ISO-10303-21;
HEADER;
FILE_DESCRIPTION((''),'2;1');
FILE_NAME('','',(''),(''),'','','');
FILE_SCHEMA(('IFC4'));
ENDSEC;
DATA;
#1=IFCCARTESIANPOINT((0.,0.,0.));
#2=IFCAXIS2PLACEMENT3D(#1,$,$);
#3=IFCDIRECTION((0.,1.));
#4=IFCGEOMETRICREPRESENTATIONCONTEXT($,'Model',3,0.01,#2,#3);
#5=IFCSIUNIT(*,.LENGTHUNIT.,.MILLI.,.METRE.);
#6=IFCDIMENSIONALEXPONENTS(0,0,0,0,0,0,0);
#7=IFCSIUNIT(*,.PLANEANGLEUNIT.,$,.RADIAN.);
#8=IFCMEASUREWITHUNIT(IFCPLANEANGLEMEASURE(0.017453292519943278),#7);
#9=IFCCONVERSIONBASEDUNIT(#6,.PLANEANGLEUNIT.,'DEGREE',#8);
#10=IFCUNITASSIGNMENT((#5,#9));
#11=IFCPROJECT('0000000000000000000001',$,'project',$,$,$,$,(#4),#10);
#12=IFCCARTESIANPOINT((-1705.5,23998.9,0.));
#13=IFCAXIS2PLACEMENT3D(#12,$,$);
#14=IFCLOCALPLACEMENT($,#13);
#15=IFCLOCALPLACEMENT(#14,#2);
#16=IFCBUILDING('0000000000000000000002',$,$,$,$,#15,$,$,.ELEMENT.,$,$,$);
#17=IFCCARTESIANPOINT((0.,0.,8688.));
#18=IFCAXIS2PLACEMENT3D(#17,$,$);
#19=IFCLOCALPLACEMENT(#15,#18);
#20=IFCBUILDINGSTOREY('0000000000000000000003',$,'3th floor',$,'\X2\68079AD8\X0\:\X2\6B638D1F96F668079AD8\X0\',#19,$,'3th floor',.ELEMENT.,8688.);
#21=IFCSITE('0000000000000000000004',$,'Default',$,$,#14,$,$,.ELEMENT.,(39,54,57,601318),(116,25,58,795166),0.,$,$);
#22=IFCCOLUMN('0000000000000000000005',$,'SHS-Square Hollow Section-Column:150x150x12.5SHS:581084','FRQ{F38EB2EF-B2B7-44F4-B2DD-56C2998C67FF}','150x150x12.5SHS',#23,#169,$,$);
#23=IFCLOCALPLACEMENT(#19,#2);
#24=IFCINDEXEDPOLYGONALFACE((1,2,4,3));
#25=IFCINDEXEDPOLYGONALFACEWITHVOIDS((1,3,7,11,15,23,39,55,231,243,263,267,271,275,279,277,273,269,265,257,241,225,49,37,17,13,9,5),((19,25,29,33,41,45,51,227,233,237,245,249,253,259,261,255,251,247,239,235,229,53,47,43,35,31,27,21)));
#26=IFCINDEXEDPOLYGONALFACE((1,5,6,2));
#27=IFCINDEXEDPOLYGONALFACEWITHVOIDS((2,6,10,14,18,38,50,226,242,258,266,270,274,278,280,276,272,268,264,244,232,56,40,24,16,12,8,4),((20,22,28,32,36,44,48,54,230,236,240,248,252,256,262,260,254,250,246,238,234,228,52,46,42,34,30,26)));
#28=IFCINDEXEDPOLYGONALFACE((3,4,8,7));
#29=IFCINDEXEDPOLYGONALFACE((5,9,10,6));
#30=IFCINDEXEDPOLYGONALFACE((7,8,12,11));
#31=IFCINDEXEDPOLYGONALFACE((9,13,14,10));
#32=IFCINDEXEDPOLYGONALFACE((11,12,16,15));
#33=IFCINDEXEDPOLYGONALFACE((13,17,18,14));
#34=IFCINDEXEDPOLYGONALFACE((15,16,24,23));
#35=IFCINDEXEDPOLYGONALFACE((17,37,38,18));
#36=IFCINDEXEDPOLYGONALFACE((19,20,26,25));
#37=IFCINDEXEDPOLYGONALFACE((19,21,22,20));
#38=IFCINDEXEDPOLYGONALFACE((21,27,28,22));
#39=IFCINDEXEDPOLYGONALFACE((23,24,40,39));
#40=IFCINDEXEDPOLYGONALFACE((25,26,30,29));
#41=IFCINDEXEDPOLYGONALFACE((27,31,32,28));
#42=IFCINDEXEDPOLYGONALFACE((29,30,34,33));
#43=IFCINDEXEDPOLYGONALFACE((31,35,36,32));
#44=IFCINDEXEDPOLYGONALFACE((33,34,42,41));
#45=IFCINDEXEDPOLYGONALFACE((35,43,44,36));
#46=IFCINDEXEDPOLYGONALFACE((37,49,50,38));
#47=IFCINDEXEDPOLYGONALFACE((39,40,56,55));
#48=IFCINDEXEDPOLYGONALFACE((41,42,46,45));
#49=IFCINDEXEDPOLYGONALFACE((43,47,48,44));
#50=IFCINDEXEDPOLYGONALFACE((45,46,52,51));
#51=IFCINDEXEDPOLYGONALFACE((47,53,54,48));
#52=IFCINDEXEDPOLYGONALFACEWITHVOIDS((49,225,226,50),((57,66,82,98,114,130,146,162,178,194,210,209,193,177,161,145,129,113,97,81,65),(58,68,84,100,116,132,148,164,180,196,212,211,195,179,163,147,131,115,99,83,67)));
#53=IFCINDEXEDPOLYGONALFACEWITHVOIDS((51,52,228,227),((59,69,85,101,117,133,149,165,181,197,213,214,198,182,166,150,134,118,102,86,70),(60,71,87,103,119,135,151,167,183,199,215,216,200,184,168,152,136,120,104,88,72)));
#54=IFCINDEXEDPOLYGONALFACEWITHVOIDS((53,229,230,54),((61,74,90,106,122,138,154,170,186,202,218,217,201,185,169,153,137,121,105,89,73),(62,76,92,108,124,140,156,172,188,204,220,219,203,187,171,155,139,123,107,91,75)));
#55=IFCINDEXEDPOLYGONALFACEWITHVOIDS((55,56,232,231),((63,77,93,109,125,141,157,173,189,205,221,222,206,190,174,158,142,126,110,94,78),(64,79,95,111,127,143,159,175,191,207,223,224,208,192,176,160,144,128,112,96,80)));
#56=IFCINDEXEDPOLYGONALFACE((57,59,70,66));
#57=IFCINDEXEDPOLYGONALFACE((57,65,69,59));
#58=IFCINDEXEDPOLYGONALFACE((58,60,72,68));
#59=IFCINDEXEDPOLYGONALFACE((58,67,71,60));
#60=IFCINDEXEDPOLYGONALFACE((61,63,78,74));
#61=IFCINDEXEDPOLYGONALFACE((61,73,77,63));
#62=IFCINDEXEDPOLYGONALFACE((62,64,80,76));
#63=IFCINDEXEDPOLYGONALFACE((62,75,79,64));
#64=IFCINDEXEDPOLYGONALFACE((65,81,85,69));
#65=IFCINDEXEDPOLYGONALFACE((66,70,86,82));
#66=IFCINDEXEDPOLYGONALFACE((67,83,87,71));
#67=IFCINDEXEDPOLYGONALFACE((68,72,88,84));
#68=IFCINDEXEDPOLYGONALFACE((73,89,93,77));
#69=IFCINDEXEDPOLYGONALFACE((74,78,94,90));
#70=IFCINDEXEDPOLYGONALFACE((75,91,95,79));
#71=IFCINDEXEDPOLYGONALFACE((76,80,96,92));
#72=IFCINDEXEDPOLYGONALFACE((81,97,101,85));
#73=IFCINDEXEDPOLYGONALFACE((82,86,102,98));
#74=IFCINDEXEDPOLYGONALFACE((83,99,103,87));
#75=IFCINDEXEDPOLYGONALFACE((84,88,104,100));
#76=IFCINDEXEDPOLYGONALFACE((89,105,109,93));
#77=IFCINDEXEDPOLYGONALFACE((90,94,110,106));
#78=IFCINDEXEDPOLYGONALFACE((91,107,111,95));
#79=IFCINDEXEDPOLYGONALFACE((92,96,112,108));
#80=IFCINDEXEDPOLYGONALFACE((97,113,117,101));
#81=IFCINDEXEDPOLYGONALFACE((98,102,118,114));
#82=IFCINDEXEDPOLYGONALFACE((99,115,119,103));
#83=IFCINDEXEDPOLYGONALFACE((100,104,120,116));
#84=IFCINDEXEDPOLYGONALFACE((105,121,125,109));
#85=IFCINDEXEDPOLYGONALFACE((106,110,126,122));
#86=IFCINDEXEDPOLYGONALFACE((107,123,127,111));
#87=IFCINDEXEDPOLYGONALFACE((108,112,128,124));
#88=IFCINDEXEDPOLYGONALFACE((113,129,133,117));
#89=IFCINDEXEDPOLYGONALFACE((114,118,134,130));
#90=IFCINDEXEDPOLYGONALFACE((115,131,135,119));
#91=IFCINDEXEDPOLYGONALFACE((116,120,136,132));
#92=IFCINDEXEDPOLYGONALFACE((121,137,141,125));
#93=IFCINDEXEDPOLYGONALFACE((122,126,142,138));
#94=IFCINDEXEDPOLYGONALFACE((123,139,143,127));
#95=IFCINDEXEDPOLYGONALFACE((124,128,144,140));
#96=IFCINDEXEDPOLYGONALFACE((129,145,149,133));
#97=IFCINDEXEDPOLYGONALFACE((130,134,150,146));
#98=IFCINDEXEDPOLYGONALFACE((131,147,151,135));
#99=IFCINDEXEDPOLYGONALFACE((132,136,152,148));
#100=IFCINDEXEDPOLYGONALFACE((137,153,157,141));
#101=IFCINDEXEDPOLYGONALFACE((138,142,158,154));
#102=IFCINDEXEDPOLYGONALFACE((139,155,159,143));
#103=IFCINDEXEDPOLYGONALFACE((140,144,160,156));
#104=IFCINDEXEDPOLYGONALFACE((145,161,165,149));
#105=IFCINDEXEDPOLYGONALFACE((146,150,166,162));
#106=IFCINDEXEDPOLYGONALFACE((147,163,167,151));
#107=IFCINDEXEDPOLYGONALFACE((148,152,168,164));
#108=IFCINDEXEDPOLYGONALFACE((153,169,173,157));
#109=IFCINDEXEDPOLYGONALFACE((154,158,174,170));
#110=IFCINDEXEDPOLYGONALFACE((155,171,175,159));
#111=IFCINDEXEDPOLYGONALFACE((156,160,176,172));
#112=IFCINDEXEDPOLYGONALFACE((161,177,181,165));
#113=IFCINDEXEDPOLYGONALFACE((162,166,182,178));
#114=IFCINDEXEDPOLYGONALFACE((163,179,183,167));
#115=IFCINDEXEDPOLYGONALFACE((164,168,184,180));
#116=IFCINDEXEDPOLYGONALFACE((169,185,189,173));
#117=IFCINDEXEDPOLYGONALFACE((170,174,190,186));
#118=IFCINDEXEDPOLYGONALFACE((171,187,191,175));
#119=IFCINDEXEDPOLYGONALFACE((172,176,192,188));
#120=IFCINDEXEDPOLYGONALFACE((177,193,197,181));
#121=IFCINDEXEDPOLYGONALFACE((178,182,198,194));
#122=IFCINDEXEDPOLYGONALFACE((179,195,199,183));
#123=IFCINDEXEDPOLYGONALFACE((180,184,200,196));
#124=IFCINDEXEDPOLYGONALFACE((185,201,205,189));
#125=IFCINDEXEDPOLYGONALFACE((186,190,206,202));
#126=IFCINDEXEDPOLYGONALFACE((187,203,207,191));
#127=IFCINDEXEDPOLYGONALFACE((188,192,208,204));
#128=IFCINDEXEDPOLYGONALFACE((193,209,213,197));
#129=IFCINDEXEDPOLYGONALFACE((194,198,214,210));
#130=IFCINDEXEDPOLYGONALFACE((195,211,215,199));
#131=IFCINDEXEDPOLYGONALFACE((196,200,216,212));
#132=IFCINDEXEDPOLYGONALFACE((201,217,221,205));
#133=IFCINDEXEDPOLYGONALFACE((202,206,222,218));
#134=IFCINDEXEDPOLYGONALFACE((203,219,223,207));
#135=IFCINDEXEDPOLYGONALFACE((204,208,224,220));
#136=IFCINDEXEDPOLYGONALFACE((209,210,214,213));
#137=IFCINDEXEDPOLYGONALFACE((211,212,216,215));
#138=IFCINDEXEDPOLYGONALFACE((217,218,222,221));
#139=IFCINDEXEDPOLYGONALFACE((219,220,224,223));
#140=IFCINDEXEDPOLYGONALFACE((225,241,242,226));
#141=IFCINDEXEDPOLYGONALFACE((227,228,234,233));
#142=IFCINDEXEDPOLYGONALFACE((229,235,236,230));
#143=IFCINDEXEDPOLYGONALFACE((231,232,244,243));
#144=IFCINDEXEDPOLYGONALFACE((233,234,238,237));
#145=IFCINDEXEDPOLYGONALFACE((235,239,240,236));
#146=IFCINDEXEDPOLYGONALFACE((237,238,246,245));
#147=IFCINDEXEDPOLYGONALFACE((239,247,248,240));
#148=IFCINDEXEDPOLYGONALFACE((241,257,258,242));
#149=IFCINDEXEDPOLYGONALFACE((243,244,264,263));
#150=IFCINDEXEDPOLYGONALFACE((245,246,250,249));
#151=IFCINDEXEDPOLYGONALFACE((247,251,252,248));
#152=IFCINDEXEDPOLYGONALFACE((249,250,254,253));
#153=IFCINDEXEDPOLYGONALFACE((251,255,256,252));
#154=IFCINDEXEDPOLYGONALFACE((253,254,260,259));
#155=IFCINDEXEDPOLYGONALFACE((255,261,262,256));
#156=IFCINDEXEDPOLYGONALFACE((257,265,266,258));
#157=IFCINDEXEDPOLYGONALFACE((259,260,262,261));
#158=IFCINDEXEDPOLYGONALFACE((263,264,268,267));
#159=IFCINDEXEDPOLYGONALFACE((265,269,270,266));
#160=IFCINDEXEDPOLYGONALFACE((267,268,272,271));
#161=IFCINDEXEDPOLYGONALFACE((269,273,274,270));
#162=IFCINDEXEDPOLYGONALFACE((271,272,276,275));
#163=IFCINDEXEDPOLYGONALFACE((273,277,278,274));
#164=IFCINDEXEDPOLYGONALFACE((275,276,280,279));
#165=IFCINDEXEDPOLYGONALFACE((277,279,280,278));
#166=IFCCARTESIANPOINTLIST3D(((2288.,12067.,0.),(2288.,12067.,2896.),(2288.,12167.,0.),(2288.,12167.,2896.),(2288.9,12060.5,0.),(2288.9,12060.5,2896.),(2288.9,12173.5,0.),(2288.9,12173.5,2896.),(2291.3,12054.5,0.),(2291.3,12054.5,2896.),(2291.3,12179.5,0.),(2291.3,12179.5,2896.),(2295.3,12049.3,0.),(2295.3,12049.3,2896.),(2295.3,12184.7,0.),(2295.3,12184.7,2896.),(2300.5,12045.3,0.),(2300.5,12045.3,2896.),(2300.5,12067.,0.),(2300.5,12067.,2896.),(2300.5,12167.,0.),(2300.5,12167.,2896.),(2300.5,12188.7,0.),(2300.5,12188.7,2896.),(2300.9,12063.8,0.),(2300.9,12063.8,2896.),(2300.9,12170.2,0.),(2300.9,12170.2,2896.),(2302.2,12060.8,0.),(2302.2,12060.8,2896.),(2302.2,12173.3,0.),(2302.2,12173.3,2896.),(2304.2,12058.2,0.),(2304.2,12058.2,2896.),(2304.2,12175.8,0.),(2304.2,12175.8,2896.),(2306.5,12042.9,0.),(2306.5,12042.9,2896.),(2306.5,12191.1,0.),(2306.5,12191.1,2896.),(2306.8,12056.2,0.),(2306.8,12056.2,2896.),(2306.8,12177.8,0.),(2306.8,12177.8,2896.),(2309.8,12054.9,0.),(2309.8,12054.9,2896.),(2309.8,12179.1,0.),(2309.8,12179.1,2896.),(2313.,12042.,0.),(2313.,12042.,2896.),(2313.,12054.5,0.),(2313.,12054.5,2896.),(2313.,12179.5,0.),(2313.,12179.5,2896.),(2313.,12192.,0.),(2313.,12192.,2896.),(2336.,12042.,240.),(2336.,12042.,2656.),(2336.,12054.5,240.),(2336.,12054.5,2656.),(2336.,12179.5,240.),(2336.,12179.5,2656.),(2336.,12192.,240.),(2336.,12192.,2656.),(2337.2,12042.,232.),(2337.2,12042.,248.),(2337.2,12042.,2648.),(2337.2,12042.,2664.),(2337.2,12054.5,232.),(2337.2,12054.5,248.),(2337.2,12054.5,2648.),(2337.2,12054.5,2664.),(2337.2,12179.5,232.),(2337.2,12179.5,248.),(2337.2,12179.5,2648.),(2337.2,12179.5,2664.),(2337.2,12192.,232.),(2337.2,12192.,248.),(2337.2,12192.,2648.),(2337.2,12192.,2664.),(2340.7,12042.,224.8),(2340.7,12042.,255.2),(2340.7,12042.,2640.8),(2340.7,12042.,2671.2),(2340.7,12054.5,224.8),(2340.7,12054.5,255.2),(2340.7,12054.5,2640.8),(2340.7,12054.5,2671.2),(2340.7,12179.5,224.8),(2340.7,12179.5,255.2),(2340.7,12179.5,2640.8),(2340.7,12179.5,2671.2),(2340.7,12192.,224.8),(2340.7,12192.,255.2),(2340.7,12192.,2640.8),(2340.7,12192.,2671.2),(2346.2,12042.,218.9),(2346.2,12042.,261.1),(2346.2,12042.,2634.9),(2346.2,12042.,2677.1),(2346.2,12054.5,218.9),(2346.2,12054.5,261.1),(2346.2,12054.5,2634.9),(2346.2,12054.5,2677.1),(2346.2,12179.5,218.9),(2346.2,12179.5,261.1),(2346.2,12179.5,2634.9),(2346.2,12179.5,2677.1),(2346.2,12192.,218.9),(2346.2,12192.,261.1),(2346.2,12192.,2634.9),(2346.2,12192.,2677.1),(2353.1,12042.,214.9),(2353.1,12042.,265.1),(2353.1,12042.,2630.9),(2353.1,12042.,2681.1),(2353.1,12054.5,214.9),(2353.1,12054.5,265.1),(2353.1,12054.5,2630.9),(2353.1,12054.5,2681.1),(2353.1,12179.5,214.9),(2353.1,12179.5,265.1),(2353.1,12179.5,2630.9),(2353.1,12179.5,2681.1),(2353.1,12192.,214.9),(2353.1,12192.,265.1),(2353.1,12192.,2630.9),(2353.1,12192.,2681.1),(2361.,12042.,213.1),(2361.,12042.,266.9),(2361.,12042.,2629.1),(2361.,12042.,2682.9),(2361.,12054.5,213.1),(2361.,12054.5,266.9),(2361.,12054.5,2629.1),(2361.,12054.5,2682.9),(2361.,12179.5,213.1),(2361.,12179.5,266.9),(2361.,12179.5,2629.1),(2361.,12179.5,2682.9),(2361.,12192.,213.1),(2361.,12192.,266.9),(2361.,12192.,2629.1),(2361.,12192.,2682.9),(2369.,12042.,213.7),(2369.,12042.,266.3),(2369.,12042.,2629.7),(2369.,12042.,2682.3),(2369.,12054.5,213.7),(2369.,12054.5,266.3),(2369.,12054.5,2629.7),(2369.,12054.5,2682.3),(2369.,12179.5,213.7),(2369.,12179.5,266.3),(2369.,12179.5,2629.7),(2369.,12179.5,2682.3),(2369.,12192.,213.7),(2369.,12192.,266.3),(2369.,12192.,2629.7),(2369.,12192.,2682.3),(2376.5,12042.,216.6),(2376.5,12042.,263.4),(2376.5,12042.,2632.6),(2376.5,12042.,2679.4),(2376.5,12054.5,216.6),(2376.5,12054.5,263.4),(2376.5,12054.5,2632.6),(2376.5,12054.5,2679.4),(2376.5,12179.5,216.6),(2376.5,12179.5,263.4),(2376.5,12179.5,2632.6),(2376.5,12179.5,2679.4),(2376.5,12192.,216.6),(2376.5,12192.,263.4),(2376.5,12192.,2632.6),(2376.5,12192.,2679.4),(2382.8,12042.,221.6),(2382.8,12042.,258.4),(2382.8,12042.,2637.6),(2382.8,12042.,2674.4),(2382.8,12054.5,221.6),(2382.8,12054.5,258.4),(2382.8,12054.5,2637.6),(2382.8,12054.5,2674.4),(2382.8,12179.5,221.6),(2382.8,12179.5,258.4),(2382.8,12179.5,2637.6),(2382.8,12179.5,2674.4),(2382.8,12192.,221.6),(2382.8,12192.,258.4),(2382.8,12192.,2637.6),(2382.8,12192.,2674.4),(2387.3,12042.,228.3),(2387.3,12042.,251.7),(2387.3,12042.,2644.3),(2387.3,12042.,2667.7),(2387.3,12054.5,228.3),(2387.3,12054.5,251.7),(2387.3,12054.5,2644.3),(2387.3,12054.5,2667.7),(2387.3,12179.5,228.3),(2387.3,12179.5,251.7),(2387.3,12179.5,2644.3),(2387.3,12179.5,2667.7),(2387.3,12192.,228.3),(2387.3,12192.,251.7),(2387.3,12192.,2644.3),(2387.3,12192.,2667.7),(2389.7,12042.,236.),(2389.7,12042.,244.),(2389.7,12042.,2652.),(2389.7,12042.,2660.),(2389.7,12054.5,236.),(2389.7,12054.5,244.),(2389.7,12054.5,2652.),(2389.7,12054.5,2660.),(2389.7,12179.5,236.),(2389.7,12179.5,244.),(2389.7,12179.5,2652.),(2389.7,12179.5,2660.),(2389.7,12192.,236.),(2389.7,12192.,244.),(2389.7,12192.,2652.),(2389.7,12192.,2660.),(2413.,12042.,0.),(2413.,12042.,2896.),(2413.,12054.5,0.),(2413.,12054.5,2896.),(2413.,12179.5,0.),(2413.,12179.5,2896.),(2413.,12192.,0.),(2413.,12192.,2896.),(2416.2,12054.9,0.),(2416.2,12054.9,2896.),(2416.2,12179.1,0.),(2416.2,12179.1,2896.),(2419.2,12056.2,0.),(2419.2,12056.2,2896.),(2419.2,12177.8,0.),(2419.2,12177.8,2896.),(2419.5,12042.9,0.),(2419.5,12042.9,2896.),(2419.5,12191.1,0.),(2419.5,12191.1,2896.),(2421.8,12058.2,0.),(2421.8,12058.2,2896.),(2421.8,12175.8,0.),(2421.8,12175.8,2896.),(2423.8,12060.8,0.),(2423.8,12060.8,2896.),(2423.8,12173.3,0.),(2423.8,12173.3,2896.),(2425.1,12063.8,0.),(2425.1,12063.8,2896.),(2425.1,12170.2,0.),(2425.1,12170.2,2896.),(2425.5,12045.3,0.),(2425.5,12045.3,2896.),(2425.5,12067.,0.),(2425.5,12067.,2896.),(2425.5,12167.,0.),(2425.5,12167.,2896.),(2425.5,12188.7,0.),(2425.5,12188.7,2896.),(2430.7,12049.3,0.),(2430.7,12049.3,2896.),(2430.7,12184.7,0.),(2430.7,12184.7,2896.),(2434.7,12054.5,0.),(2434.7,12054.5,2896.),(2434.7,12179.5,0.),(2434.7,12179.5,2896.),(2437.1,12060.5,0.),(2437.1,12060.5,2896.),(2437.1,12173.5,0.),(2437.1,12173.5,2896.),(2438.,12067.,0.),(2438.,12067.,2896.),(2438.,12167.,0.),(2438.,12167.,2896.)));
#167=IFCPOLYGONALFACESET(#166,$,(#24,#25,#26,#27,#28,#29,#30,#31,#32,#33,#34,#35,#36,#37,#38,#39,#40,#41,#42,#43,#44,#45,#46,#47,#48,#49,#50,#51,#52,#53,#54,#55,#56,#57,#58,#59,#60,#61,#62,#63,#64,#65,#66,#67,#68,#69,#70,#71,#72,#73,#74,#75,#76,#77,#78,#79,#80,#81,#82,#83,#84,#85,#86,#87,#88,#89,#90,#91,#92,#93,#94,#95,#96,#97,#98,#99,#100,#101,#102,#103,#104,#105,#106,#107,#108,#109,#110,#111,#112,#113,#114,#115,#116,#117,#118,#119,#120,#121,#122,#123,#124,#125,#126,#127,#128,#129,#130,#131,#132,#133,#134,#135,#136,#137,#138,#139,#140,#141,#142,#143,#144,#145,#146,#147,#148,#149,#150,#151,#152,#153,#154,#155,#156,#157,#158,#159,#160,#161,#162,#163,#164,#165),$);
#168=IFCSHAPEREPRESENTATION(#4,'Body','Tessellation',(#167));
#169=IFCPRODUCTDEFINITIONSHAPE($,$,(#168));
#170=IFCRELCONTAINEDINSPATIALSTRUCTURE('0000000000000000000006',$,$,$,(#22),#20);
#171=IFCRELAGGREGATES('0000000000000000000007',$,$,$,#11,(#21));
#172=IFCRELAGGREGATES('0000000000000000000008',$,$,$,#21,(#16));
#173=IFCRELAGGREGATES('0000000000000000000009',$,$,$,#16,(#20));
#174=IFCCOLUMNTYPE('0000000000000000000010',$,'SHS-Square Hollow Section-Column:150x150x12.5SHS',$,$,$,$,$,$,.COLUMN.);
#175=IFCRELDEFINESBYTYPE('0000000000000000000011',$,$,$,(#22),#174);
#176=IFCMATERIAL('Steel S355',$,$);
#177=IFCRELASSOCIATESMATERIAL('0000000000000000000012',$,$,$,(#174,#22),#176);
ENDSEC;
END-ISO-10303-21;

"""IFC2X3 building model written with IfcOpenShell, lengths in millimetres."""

from ifc_helpers import new_model, entity, si_unit, converted_unit, direction, frame, frame_2d, origin, origin_2d, place, context, project, spatial, circle_curve, hollow_rectangle, outline, extrude, material, type_object, element, save


model = new_model("IFC2X3")

# Units and contexts
model_context = context("Model", 3, precision=0.01, world=origin(), true_north=direction((0.0, 1.0)))
ifc_project = project(units=[si_unit("LENGTHUNIT", "METRE", prefix="MILLI"), converted_unit("PLANEANGLEUNIT", "DEGREE", entity("IfcPlaneAngleMeasure", 0.017453292519943278), si_unit("PLANEANGLEUNIT", "RADIAN"), dimensions=[0, 0, 0, 0, 0, 0, 0])], contexts=[model_context])

# Site, building, storey
site_placement = place(None, frame((-1705.5, 23998.9, 0.0)))
site = spatial("IfcSite", under=ifc_project, at=site_placement, Name="Default", CompositionType="ELEMENT", RefLatitude=(39, 54, 57, 601318), RefLongitude=(116, 25, 58, 795166), RefElevation=0.0)
building_placement = place(site_placement, origin())
building = spatial("IfcBuilding", under=site, at=building_placement, CompositionType="ELEMENT")
storey_placement = place(building_placement, frame((0.0, 0.0, 8688.0)))
storey = spatial("IfcBuildingStorey", under=building, at=storey_placement, Name="3th floor", ObjectType="标高:正负零标高", LongName="3th floor", CompositionType="ELEMENT", Elevation=8688.0)

# Column, openings
ifc_material_1 = material(Name="Steel S355")
column_type_1 = type_object("IfcColumnType", Name="SHS-Square Hollow Section-Column:150x150x12.5SHS", PredefinedType="COLUMN", material=ifc_material_1)
column_1_placement = place(storey_placement, frame((2363.0, 12117.0, 2896.0), z_axis=(0.0, 0.0, 1.0), x_axis=(0.0, -1.0, 0.0)))
column_1 = element("IfcColumn", 1, at=column_1_placement, inside=storey, type_object=column_type_1, material=ifc_material_1, Name="SHS-Square Hollow Section-Column:150x150x12.5SHS:581084", Description="FRQ{F38EB2EF-B2B7-44F4-B2DD-56C2998C67FF}", ObjectType="150x150x12.5SHS", context=model_context, shape_type="SweptSolid", body=[
    extrude(hollow_rectangle(XDim=150.0, YDim=150.0, WallThickness=12.5, InnerFilletRadius=12.5, OuterFilletRadius=25.0, at=origin_2d()), origin(), (0.0, 0.0, -1.0), 2896.0),
])
opening_1_placement = place(column_1_placement, frame((175.1, 0.0, 0.0), z_axis=(-1.0, 0.0, 0.0), x_axis=(0.0, -1.0, 0.0)))
element("IfcOpeningElement", 2, at=opening_1_placement, cuts=column_1, ObjectType="Opening", context=model_context, shape_type="SweptSolid", body=[
    extrude(outline(circle_curve(frame_2d((0.0, -240.0), x_axis=(1.0, 0.0)), 27.0)), origin(), (0.0, 0.0, 1.0), 350.2),
])
opening_2_placement = place(column_1_placement, frame((175.1, 0.0, -2896.0), z_axis=(-1.0, 0.0, 0.0), x_axis=(0.0, -1.0, 0.0)))
element("IfcOpeningElement", 3, at=opening_2_placement, cuts=column_1, ObjectType="Opening", context=model_context, shape_type="SweptSolid", body=[
    extrude(outline(circle_curve(frame_2d((0.0, 240.0), x_axis=(1.0, 0.0)), 27.0)), origin(), (0.0, 0.0, 1.0), 350.2),
])

save(model, "model.ifc")
